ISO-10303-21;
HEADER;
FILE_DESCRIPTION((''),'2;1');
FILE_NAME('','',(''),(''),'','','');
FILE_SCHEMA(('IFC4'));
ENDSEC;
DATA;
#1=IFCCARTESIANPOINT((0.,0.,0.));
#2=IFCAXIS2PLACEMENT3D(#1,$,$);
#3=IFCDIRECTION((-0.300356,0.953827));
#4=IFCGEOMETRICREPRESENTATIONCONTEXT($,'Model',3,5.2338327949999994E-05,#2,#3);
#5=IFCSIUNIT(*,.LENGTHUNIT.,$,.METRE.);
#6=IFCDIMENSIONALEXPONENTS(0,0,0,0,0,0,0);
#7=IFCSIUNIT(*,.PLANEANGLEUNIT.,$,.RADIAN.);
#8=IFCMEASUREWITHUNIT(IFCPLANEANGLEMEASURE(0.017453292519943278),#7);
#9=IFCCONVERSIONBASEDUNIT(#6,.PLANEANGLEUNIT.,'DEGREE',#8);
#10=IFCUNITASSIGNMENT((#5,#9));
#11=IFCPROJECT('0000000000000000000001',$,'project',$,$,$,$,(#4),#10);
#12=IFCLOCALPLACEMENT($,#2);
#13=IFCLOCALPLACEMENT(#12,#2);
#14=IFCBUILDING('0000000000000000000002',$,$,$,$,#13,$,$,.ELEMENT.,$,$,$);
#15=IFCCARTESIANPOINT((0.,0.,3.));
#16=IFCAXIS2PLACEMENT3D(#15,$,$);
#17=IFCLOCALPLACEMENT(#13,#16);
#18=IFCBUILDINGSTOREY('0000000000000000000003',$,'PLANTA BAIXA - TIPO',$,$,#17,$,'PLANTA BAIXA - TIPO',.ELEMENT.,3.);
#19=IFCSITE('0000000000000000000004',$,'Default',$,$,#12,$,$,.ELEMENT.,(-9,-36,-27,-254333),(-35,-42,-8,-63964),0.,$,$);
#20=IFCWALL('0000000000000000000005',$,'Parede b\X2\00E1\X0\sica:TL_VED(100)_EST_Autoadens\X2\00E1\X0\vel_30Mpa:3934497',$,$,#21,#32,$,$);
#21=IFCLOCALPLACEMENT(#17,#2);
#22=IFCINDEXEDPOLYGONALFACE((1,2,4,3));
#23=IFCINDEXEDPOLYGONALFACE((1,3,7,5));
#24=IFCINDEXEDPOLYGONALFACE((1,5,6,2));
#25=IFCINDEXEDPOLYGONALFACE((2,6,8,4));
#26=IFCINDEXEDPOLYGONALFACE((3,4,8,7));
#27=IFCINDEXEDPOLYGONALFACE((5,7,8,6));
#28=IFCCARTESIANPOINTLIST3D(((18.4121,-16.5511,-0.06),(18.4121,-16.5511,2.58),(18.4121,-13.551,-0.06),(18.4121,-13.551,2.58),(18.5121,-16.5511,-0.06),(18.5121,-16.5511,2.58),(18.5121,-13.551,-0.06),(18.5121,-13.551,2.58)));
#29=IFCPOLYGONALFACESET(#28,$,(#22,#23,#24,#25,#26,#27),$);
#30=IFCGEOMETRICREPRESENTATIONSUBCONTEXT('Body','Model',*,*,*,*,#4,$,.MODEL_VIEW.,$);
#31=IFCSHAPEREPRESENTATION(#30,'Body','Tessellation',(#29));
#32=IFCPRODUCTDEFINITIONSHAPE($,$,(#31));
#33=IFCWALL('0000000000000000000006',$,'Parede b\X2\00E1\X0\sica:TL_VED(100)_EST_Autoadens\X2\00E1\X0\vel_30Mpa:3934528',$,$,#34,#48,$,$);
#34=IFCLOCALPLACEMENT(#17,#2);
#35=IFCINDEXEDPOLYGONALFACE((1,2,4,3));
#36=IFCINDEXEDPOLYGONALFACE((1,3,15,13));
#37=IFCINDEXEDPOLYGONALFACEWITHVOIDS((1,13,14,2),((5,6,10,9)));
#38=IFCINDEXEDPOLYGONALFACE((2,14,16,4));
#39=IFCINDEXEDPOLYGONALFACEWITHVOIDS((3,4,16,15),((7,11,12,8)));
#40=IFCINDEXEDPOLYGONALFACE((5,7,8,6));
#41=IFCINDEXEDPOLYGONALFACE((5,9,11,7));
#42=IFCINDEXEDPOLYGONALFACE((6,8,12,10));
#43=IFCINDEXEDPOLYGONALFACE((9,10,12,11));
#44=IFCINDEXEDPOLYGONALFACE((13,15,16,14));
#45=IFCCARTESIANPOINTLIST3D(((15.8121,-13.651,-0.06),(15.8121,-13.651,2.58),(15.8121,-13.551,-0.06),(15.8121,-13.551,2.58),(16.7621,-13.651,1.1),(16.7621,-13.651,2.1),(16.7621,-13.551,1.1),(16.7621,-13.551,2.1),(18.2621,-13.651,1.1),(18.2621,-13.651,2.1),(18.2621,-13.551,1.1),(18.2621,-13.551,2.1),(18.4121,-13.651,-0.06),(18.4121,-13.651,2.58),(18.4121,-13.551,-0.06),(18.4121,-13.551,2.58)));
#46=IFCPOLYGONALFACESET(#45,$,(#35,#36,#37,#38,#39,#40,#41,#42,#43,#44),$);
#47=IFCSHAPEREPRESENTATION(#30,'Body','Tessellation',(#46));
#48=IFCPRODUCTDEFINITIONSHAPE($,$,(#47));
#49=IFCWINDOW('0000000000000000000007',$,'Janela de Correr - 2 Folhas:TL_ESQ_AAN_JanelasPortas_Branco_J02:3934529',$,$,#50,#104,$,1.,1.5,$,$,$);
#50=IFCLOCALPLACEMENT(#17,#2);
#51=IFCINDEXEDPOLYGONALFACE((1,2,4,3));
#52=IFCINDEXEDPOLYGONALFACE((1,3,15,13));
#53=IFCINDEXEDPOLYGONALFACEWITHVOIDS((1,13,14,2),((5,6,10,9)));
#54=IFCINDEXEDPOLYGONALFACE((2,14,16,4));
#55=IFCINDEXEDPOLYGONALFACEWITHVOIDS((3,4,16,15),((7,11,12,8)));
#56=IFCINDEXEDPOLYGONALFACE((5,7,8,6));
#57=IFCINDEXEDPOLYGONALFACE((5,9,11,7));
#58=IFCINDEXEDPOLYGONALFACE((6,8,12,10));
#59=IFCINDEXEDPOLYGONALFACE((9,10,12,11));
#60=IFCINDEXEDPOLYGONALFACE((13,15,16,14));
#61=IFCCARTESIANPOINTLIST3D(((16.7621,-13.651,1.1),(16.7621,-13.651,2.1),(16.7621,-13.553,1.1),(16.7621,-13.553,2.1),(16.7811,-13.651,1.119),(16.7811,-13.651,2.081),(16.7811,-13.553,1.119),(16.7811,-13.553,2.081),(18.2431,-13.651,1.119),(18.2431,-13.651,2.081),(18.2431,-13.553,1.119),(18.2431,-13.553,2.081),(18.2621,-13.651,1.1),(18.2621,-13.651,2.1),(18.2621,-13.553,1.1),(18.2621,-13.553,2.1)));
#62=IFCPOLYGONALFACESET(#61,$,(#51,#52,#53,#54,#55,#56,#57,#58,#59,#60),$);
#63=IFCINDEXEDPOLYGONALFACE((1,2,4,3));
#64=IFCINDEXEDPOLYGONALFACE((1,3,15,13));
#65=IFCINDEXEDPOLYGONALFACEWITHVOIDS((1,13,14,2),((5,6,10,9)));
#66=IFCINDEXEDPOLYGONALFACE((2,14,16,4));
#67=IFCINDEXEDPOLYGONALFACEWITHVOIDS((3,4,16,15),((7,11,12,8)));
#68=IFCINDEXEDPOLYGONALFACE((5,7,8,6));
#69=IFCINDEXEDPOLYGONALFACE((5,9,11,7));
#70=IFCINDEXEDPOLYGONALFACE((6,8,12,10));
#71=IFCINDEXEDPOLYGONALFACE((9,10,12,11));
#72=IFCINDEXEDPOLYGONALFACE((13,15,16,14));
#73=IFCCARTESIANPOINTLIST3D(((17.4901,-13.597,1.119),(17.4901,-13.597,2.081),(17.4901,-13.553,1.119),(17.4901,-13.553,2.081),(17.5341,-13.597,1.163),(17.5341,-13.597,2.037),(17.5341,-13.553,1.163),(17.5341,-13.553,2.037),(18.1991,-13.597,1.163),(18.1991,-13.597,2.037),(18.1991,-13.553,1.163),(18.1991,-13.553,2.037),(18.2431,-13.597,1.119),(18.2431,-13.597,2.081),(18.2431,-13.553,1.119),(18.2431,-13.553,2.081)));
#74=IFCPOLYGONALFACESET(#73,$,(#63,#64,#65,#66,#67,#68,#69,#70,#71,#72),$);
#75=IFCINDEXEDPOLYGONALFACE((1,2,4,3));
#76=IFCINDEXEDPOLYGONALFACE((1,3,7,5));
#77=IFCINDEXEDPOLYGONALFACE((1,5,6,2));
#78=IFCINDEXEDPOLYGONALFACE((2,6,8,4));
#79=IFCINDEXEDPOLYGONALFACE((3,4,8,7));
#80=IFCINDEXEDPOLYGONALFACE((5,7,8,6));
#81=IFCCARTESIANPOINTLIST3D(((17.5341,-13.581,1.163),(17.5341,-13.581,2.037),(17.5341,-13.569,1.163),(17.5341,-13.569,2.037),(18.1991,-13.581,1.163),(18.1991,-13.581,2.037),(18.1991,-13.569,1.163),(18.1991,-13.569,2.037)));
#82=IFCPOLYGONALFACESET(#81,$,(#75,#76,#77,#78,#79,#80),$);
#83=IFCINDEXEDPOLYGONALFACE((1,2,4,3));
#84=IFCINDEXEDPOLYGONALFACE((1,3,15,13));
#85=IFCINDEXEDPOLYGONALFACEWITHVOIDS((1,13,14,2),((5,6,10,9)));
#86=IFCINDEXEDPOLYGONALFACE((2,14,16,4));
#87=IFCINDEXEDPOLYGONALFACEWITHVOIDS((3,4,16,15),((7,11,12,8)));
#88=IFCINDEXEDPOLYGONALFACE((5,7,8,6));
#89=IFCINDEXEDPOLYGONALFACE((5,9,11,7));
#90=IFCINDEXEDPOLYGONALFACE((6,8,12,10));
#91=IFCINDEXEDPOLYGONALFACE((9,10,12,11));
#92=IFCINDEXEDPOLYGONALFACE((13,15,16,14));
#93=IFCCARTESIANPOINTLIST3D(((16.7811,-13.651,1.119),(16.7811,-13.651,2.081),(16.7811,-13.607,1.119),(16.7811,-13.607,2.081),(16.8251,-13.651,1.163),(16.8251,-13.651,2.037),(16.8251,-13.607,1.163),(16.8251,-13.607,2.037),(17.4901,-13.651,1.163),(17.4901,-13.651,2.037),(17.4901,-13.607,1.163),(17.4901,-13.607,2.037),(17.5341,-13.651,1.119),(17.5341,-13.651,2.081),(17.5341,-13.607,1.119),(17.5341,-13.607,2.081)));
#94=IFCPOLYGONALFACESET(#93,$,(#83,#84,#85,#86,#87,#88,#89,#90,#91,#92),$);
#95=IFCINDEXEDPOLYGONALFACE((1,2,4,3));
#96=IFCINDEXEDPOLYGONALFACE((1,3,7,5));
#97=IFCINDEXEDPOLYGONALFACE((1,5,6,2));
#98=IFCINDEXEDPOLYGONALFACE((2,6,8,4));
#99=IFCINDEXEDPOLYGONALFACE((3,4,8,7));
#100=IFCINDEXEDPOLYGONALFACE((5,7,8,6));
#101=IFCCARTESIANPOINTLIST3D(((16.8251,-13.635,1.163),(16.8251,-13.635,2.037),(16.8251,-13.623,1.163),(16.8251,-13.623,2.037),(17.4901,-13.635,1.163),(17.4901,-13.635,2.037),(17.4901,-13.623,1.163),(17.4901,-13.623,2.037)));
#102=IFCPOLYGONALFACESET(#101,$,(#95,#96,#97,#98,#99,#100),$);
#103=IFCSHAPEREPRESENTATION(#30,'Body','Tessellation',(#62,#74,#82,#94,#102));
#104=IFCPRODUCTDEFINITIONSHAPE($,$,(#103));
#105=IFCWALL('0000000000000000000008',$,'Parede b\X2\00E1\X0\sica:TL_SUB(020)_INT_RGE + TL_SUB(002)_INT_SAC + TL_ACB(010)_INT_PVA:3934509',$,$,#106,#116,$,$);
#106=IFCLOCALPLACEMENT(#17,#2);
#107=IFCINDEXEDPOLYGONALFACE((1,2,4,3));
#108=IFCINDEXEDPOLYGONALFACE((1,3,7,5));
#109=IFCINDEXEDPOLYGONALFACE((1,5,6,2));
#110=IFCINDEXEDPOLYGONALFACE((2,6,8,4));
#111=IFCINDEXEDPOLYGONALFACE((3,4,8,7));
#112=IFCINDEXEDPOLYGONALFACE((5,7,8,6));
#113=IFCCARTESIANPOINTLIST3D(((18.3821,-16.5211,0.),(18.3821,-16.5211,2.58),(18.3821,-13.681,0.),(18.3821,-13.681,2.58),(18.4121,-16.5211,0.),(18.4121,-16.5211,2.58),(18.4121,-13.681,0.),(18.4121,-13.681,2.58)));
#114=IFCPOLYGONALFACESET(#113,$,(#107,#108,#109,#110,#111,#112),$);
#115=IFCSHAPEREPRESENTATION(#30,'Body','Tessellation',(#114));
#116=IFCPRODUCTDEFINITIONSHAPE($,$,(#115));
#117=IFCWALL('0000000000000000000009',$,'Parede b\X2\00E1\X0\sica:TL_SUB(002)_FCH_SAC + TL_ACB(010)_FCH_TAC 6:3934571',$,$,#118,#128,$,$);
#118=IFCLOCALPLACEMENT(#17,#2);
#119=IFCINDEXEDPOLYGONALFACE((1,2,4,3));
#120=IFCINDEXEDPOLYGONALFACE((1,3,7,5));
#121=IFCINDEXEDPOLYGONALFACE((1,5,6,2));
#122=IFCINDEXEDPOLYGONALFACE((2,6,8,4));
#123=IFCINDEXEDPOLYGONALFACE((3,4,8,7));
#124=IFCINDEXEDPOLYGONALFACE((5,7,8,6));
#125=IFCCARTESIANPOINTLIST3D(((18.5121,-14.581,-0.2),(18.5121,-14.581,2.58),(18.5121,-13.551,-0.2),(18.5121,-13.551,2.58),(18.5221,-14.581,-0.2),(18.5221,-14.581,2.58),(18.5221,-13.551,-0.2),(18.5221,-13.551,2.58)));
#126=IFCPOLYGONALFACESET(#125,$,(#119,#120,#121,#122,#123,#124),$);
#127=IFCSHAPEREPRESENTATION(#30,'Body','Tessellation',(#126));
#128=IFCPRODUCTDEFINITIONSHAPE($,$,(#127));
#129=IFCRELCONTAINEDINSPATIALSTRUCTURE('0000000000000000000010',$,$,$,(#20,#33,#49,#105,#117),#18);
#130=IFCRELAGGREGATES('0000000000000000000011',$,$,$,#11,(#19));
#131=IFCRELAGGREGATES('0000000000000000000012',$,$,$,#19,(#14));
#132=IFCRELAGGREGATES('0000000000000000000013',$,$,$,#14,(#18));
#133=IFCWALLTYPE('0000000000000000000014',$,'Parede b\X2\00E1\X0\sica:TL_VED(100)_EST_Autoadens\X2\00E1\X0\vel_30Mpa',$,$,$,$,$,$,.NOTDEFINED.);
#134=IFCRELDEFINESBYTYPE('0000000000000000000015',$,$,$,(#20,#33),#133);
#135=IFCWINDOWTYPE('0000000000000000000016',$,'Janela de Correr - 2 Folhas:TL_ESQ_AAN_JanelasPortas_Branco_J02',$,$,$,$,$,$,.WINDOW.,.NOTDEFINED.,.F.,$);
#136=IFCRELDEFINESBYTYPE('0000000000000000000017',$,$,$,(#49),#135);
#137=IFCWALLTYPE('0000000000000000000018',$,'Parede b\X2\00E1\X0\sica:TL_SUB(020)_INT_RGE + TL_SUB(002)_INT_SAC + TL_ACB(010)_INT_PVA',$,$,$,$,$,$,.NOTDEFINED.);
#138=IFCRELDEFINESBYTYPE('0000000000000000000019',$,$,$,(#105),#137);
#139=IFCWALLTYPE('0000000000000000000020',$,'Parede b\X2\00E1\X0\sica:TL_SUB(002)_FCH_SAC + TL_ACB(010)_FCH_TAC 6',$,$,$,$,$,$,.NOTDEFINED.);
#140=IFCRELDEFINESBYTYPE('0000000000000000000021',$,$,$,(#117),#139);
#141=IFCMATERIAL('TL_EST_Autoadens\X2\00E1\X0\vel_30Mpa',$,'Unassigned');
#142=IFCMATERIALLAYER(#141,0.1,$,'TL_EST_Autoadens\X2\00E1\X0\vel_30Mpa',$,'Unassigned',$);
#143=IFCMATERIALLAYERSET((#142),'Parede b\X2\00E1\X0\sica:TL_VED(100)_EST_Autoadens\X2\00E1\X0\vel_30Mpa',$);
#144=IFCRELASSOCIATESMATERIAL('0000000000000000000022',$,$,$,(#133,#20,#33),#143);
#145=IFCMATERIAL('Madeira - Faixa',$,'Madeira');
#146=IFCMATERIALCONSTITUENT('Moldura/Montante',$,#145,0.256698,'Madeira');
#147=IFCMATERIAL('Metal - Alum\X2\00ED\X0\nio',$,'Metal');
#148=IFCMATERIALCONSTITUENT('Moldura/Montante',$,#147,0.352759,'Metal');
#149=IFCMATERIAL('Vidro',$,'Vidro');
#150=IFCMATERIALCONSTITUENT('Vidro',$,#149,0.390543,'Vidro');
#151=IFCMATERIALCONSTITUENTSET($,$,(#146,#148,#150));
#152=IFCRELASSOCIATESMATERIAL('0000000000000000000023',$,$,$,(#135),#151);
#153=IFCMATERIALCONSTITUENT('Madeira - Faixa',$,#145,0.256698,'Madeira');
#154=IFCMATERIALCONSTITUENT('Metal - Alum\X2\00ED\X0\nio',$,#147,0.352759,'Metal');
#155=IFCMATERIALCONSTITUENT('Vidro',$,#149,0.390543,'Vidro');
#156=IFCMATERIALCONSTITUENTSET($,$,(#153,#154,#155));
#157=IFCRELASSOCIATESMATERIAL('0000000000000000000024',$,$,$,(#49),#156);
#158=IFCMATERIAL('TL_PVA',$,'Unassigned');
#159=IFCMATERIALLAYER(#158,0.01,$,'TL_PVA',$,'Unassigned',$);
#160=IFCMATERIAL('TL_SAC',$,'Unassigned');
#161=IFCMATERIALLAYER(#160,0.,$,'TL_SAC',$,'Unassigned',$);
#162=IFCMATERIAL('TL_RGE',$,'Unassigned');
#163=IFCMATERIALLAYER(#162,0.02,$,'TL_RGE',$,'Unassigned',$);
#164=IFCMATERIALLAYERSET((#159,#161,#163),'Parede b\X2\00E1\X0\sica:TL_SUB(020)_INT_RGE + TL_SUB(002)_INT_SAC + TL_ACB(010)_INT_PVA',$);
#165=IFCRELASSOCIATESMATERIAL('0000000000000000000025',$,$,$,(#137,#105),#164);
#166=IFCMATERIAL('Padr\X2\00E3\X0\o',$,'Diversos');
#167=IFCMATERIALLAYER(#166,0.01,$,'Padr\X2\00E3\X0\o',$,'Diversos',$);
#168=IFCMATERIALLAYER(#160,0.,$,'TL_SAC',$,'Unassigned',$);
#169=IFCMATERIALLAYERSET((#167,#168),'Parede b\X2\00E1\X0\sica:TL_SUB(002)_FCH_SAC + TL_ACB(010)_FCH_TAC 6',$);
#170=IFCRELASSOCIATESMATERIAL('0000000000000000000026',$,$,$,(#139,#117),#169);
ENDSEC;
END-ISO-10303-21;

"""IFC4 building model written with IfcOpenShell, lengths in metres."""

from ifc_helpers import new_model, entity, si_unit, converted_unit, direction, frame, frame_2d, origin, origin_2d_with_axis, place, context, subcontext, project, spatial, polyline, rectangle, outline, extrude, source, transform, mapped, material, layer, layer_set, layer_usage, constituent, constituent_set, type_object, type_shapes, element, fill, save


model = new_model("IFC4")

# Units and contexts
model_context = context("Model", 3, precision=5.2338327949999994e-05, world=origin(), true_north=direction((-0.300356, 0.953827)))
body_context = subcontext(model_context, "Body", "Model", "MODEL_VIEW")
ifc_project = project(units=[si_unit("LENGTHUNIT", "METRE"), converted_unit("PLANEANGLEUNIT", "DEGREE", entity("IfcPlaneAngleMeasure", 0.017453292519943278), si_unit("PLANEANGLEUNIT", "RADIAN"), dimensions=[0, 0, 0, 0, 0, 0, 0])], contexts=[model_context])

# Site, building, storey
site_placement = place(None, origin())
site = spatial("IfcSite", under=ifc_project, at=site_placement, Name="Default", CompositionType="ELEMENT", RefLatitude=(-9, -36, -27, -254333), RefLongitude=(-35, -42, -8, -63964), RefElevation=0.0)
building_placement = place(site_placement, origin())
building = spatial("IfcBuilding", under=site, at=building_placement, CompositionType="ELEMENT")
storey_placement = place(building_placement, frame((0.0, 0.0, 3.0)))
storey = spatial("IfcBuildingStorey", under=building, at=storey_placement, Name="PLANTA BAIXA - TIPO", LongName="PLANTA BAIXA - TIPO", CompositionType="ELEMENT", Elevation=3.0)

# Wall
ifc_material_1 = material(Name="TL_EST_Autoadensável_30Mpa", Category="Unassigned")
ifc_layer_1 = layer(ifc_material_1, 0.1, Name="TL_EST_Autoadensável_30Mpa", Category="Unassigned")
ifc_layer_set_1 = layer_set([ifc_layer_1], Name="Parede básica:TL_VED(100)_EST_Autoadensável_30Mpa")
ifc_layer_usage_1 = layer_usage(ifc_layer_set_1, "AXIS2", "POSITIVE", -0.05)
wall_type_1 = type_object("IfcWallType", Name="Parede básica:TL_VED(100)_EST_Autoadensável_30Mpa", PredefinedType="NOTDEFINED", material=ifc_layer_set_1)
wall_1_placement = place(storey_placement, frame((18.4621, -13.551, -0.06), z_axis=(0.0, 0.0, 1.0), x_axis=(0.0, -1.0, 0.0)))
element("IfcWall", 1, at=wall_1_placement, inside=storey, type_object=wall_type_1, material=ifc_layer_usage_1, Name="Parede básica:TL_VED(100)_EST_Autoadensável_30Mpa:3934497", context=body_context, shape_type="SweptSolid", body=[
    extrude(rectangle(XDim=3.0001, YDim=0.1, at=frame_2d((1.5001, 0.0), x_axis=(-1.0, 0.0))), origin(), (0.0, 0.0, 1.0), 2.64),
])

# Wall, opening, window
ifc_layer_usage_2 = layer_usage(ifc_layer_set_1, "AXIS2", "POSITIVE", -0.05)
wall_2_placement = place(storey_placement, frame((18.4121, -13.601, -0.06), z_axis=(0.0, 0.0, 1.0), x_axis=(-1.0, 0.0, 0.0)))
wall_2 = element("IfcWall", 2, at=wall_2_placement, inside=storey, type_object=wall_type_1, material=ifc_layer_usage_2, Name="Parede básica:TL_VED(100)_EST_Autoadensável_30Mpa:3934528", context=body_context, shape_type="SweptSolid", body=[
    extrude(rectangle(XDim=2.6, YDim=0.1, at=frame_2d((1.3, 0.0), x_axis=(-1.0, 0.0))), origin(), (0.0, 0.0, 1.0), 2.64),
])
opening_placement = place(wall_2_placement, frame((1.65, 0.05, 1.16)))
opening = element("IfcOpeningElement", 3, at=opening_placement, cuts=wall_2, PredefinedType="OPENING", context=body_context, shape_type="SweptSolid", body=[
    extrude(rectangle(XDim=1.0, YDim=1.5, at=frame_2d((0.5, 0.75), x_axis=(-1.0, 0.0))), frame((0.0, 0.0, 0.0), z_axis=(0.0, -1.0, 0.0), x_axis=(0.0, 0.0, 1.0)), (0.0, 0.0, 1.0), 0.1),
])
ifc_material_2 = material(Name="Madeira - Faixa", Category="Madeira")
ifc_constituent_1 = constituent(ifc_material_2, Name="Madeira - Faixa", Category="Madeira", fraction=0.256698)
ifc_material_3 = material(Name="Metal - Alumínio", Category="Metal")
ifc_constituent_2 = constituent(ifc_material_3, Name="Metal - Alumínio", Category="Metal", fraction=0.352759)
ifc_material_4 = material(Name="Vidro", Category="Vidro")
ifc_constituent_3 = constituent(ifc_material_4, Name="Vidro", Category="Vidro", fraction=0.390543)
ifc_constituent_set_1 = constituent_set(constituents=[ifc_constituent_1, ifc_constituent_2, ifc_constituent_3])
ifc_constituent_4 = constituent(ifc_material_2, Name="Moldura/Montante", Category="Madeira", fraction=0.256698)
ifc_constituent_5 = constituent(ifc_material_3, Name="Moldura/Montante", Category="Metal", fraction=0.352759)
ifc_constituent_6 = constituent(ifc_material_4, Name="Vidro", Category="Vidro", fraction=0.390543)
ifc_constituent_set_2 = constituent_set(constituents=[ifc_constituent_4, ifc_constituent_5, ifc_constituent_6])
window_type = type_object("IfcWindowType", Name="Janela de Correr - 2 Folhas:TL_ESQ_AAN_JanelasPortas_Branco_J02", ParameterTakesPrecedence=False, PartitioningType="NOTDEFINED", PredefinedType="WINDOW", material=ifc_constituent_set_2)
shared_shape_1 = source(origin(), body_context, "Body", "SweptSolid", [
    extrude(outline(polyline([(-0.75, -0.5), (0.75, -0.5), (0.75, 0.5), (-0.75, 0.5), (-0.75, -0.5)]), holes=[polyline([(-0.731, -0.481), (-0.731, 0.481), (0.731, 0.481), (0.731, -0.481), (-0.731, -0.481)])]), frame((0.75, 0.0, 0.5), z_axis=(0.0, 1.0, 0.0), x_axis=(1.0, 0.0, 0.0)), (0.0, 0.0, 1.0), 0.098),
    extrude(outline(polyline([(-0.3765, -0.481), (0.3765, -0.481), (0.3765, 0.481), (-0.3765, 0.481), (-0.3765, -0.481)]), holes=[polyline([(-0.3325, -0.437), (-0.3325, 0.437), (0.3325, 0.437), (0.3325, -0.437), (-0.3325, -0.437)])]), frame((1.1045, 0.054, 0.5), z_axis=(0.0, 1.0, 0.0), x_axis=(1.0, 0.0, 0.0)), (0.0, 0.0, 1.0), 0.044),
    extrude(rectangle(XDim=0.012, YDim=0.665, at=origin_2d_with_axis()), frame((1.1045, 0.076, 0.063), z_axis=(0.0, 0.0, 1.0), x_axis=(0.0, -1.0, 0.0)), (0.0, 0.0, 1.0), 0.874),
    extrude(outline(polyline([(-0.481, -0.3765), (0.481, -0.3765), (0.481, 0.3765), (-0.481, 0.3765), (-0.481, -0.3765)]), holes=[polyline([(-0.437, -0.3325), (-0.437, 0.3325), (0.437, 0.3325), (0.437, -0.3325), (-0.437, -0.3325)])]), frame((0.3955, 0.0, 0.5), z_axis=(0.0, 1.0, 0.0), x_axis=(0.0, 0.0, -1.0)), (0.0, 0.0, 1.0), 0.044),
    extrude(rectangle(XDim=0.012, YDim=0.665, at=origin_2d_with_axis()), frame((0.3955, 0.022, 0.063), z_axis=(0.0, 0.0, 1.0), x_axis=(0.0, -1.0, 0.0)), (0.0, 0.0, 1.0), 0.874),
])
type_shapes(window_type, [shared_shape_1])
window_placement = place(opening_placement, frame((0.0, 0.0, 0.0), z_axis=(0.0, 0.0, 1.0), x_axis=(-1.0, 0.0, 0.0)))
window = element("IfcWindow", 4, at=window_placement, inside=storey, type_object=window_type, material=ifc_constituent_set_1, Name="Janela de Correr - 2 Folhas:TL_ESQ_AAN_JanelasPortas_Branco_J02:3934529", OverallHeight=1.0, OverallWidth=1.5, context=body_context, shape_type="MappedRepresentation", body=[
    mapped(shared_shape_1, transform((0.0, 0.0, 0.0), scale=1.0)),
])
fill(opening, window)

# Walls
ifc_material_5 = material(Name="TL_PVA", Category="Unassigned")
ifc_layer_2 = layer(ifc_material_5, 0.01, Name="TL_PVA", Category="Unassigned")
ifc_material_6 = material(Name="TL_SAC", Category="Unassigned")
ifc_layer_3 = layer(ifc_material_6, 0.0, Name="TL_SAC", Category="Unassigned")
ifc_material_7 = material(Name="TL_RGE", Category="Unassigned")
ifc_layer_4 = layer(ifc_material_7, 0.02, Name="TL_RGE", Category="Unassigned")
ifc_layer_set_2 = layer_set([ifc_layer_2, ifc_layer_3, ifc_layer_4], Name="Parede básica:TL_SUB(020)_INT_RGE + TL_SUB(002)_INT_SAC + TL_ACB(010)_INT_PVA")
ifc_layer_usage_3 = layer_usage(ifc_layer_set_2, "AXIS2", "POSITIVE", -0.015)
wall_type_2 = type_object("IfcWallType", Name="Parede básica:TL_SUB(020)_INT_RGE + TL_SUB(002)_INT_SAC + TL_ACB(010)_INT_PVA", PredefinedType="NOTDEFINED", material=ifc_layer_set_2)
wall_3_placement = place(storey_placement, frame((18.3971, -13.681, 0.0), z_axis=(0.0, 0.0, 1.0), x_axis=(0.0, -1.0, 0.0)))
element("IfcWall", 5, at=wall_3_placement, inside=storey, type_object=wall_type_2, material=ifc_layer_usage_3, Name="Parede básica:TL_SUB(020)_INT_RGE + TL_SUB(002)_INT_SAC + TL_ACB(010)_INT_PVA:3934509", context=body_context, shape_type="SweptSolid", body=[
    extrude(rectangle(XDim=2.8401, YDim=0.03, at=frame_2d((1.4201, 0.0), x_axis=(-1.0, 0.0))), origin(), (0.0, 0.0, 1.0), 2.58),
])
ifc_material_8 = material(Name="Padrão", Category="Diversos")
ifc_layer_5 = layer(ifc_material_8, 0.01, Name="Padrão", Category="Diversos")
ifc_layer_6 = layer(ifc_material_6, 0.0, Name="TL_SAC", Category="Unassigned")
ifc_layer_set_3 = layer_set([ifc_layer_5, ifc_layer_6], Name="Parede básica:TL_SUB(002)_FCH_SAC + TL_ACB(010)_FCH_TAC 6")
ifc_layer_usage_4 = layer_usage(ifc_layer_set_3, "AXIS2", "POSITIVE", -0.005)
wall_type_3 = type_object("IfcWallType", Name="Parede básica:TL_SUB(002)_FCH_SAC + TL_ACB(010)_FCH_TAC 6", PredefinedType="NOTDEFINED", material=ifc_layer_set_3)
wall_4_placement = place(storey_placement, frame((18.5171, -13.551, -0.2), z_axis=(0.0, 0.0, 1.0), x_axis=(0.0, -1.0, 0.0)))
element("IfcWall", 6, at=wall_4_placement, inside=storey, type_object=wall_type_3, material=ifc_layer_usage_4, Name="Parede básica:TL_SUB(002)_FCH_SAC + TL_ACB(010)_FCH_TAC 6:3934571", context=body_context, shape_type="SweptSolid", body=[
    extrude(rectangle(XDim=1.03, YDim=0.01, at=frame_2d((0.515, 0.0), x_axis=(-1.0, 0.0))), origin(), (0.0, 0.0, 1.0), 2.78),
])

save(model, "model.ifc")
